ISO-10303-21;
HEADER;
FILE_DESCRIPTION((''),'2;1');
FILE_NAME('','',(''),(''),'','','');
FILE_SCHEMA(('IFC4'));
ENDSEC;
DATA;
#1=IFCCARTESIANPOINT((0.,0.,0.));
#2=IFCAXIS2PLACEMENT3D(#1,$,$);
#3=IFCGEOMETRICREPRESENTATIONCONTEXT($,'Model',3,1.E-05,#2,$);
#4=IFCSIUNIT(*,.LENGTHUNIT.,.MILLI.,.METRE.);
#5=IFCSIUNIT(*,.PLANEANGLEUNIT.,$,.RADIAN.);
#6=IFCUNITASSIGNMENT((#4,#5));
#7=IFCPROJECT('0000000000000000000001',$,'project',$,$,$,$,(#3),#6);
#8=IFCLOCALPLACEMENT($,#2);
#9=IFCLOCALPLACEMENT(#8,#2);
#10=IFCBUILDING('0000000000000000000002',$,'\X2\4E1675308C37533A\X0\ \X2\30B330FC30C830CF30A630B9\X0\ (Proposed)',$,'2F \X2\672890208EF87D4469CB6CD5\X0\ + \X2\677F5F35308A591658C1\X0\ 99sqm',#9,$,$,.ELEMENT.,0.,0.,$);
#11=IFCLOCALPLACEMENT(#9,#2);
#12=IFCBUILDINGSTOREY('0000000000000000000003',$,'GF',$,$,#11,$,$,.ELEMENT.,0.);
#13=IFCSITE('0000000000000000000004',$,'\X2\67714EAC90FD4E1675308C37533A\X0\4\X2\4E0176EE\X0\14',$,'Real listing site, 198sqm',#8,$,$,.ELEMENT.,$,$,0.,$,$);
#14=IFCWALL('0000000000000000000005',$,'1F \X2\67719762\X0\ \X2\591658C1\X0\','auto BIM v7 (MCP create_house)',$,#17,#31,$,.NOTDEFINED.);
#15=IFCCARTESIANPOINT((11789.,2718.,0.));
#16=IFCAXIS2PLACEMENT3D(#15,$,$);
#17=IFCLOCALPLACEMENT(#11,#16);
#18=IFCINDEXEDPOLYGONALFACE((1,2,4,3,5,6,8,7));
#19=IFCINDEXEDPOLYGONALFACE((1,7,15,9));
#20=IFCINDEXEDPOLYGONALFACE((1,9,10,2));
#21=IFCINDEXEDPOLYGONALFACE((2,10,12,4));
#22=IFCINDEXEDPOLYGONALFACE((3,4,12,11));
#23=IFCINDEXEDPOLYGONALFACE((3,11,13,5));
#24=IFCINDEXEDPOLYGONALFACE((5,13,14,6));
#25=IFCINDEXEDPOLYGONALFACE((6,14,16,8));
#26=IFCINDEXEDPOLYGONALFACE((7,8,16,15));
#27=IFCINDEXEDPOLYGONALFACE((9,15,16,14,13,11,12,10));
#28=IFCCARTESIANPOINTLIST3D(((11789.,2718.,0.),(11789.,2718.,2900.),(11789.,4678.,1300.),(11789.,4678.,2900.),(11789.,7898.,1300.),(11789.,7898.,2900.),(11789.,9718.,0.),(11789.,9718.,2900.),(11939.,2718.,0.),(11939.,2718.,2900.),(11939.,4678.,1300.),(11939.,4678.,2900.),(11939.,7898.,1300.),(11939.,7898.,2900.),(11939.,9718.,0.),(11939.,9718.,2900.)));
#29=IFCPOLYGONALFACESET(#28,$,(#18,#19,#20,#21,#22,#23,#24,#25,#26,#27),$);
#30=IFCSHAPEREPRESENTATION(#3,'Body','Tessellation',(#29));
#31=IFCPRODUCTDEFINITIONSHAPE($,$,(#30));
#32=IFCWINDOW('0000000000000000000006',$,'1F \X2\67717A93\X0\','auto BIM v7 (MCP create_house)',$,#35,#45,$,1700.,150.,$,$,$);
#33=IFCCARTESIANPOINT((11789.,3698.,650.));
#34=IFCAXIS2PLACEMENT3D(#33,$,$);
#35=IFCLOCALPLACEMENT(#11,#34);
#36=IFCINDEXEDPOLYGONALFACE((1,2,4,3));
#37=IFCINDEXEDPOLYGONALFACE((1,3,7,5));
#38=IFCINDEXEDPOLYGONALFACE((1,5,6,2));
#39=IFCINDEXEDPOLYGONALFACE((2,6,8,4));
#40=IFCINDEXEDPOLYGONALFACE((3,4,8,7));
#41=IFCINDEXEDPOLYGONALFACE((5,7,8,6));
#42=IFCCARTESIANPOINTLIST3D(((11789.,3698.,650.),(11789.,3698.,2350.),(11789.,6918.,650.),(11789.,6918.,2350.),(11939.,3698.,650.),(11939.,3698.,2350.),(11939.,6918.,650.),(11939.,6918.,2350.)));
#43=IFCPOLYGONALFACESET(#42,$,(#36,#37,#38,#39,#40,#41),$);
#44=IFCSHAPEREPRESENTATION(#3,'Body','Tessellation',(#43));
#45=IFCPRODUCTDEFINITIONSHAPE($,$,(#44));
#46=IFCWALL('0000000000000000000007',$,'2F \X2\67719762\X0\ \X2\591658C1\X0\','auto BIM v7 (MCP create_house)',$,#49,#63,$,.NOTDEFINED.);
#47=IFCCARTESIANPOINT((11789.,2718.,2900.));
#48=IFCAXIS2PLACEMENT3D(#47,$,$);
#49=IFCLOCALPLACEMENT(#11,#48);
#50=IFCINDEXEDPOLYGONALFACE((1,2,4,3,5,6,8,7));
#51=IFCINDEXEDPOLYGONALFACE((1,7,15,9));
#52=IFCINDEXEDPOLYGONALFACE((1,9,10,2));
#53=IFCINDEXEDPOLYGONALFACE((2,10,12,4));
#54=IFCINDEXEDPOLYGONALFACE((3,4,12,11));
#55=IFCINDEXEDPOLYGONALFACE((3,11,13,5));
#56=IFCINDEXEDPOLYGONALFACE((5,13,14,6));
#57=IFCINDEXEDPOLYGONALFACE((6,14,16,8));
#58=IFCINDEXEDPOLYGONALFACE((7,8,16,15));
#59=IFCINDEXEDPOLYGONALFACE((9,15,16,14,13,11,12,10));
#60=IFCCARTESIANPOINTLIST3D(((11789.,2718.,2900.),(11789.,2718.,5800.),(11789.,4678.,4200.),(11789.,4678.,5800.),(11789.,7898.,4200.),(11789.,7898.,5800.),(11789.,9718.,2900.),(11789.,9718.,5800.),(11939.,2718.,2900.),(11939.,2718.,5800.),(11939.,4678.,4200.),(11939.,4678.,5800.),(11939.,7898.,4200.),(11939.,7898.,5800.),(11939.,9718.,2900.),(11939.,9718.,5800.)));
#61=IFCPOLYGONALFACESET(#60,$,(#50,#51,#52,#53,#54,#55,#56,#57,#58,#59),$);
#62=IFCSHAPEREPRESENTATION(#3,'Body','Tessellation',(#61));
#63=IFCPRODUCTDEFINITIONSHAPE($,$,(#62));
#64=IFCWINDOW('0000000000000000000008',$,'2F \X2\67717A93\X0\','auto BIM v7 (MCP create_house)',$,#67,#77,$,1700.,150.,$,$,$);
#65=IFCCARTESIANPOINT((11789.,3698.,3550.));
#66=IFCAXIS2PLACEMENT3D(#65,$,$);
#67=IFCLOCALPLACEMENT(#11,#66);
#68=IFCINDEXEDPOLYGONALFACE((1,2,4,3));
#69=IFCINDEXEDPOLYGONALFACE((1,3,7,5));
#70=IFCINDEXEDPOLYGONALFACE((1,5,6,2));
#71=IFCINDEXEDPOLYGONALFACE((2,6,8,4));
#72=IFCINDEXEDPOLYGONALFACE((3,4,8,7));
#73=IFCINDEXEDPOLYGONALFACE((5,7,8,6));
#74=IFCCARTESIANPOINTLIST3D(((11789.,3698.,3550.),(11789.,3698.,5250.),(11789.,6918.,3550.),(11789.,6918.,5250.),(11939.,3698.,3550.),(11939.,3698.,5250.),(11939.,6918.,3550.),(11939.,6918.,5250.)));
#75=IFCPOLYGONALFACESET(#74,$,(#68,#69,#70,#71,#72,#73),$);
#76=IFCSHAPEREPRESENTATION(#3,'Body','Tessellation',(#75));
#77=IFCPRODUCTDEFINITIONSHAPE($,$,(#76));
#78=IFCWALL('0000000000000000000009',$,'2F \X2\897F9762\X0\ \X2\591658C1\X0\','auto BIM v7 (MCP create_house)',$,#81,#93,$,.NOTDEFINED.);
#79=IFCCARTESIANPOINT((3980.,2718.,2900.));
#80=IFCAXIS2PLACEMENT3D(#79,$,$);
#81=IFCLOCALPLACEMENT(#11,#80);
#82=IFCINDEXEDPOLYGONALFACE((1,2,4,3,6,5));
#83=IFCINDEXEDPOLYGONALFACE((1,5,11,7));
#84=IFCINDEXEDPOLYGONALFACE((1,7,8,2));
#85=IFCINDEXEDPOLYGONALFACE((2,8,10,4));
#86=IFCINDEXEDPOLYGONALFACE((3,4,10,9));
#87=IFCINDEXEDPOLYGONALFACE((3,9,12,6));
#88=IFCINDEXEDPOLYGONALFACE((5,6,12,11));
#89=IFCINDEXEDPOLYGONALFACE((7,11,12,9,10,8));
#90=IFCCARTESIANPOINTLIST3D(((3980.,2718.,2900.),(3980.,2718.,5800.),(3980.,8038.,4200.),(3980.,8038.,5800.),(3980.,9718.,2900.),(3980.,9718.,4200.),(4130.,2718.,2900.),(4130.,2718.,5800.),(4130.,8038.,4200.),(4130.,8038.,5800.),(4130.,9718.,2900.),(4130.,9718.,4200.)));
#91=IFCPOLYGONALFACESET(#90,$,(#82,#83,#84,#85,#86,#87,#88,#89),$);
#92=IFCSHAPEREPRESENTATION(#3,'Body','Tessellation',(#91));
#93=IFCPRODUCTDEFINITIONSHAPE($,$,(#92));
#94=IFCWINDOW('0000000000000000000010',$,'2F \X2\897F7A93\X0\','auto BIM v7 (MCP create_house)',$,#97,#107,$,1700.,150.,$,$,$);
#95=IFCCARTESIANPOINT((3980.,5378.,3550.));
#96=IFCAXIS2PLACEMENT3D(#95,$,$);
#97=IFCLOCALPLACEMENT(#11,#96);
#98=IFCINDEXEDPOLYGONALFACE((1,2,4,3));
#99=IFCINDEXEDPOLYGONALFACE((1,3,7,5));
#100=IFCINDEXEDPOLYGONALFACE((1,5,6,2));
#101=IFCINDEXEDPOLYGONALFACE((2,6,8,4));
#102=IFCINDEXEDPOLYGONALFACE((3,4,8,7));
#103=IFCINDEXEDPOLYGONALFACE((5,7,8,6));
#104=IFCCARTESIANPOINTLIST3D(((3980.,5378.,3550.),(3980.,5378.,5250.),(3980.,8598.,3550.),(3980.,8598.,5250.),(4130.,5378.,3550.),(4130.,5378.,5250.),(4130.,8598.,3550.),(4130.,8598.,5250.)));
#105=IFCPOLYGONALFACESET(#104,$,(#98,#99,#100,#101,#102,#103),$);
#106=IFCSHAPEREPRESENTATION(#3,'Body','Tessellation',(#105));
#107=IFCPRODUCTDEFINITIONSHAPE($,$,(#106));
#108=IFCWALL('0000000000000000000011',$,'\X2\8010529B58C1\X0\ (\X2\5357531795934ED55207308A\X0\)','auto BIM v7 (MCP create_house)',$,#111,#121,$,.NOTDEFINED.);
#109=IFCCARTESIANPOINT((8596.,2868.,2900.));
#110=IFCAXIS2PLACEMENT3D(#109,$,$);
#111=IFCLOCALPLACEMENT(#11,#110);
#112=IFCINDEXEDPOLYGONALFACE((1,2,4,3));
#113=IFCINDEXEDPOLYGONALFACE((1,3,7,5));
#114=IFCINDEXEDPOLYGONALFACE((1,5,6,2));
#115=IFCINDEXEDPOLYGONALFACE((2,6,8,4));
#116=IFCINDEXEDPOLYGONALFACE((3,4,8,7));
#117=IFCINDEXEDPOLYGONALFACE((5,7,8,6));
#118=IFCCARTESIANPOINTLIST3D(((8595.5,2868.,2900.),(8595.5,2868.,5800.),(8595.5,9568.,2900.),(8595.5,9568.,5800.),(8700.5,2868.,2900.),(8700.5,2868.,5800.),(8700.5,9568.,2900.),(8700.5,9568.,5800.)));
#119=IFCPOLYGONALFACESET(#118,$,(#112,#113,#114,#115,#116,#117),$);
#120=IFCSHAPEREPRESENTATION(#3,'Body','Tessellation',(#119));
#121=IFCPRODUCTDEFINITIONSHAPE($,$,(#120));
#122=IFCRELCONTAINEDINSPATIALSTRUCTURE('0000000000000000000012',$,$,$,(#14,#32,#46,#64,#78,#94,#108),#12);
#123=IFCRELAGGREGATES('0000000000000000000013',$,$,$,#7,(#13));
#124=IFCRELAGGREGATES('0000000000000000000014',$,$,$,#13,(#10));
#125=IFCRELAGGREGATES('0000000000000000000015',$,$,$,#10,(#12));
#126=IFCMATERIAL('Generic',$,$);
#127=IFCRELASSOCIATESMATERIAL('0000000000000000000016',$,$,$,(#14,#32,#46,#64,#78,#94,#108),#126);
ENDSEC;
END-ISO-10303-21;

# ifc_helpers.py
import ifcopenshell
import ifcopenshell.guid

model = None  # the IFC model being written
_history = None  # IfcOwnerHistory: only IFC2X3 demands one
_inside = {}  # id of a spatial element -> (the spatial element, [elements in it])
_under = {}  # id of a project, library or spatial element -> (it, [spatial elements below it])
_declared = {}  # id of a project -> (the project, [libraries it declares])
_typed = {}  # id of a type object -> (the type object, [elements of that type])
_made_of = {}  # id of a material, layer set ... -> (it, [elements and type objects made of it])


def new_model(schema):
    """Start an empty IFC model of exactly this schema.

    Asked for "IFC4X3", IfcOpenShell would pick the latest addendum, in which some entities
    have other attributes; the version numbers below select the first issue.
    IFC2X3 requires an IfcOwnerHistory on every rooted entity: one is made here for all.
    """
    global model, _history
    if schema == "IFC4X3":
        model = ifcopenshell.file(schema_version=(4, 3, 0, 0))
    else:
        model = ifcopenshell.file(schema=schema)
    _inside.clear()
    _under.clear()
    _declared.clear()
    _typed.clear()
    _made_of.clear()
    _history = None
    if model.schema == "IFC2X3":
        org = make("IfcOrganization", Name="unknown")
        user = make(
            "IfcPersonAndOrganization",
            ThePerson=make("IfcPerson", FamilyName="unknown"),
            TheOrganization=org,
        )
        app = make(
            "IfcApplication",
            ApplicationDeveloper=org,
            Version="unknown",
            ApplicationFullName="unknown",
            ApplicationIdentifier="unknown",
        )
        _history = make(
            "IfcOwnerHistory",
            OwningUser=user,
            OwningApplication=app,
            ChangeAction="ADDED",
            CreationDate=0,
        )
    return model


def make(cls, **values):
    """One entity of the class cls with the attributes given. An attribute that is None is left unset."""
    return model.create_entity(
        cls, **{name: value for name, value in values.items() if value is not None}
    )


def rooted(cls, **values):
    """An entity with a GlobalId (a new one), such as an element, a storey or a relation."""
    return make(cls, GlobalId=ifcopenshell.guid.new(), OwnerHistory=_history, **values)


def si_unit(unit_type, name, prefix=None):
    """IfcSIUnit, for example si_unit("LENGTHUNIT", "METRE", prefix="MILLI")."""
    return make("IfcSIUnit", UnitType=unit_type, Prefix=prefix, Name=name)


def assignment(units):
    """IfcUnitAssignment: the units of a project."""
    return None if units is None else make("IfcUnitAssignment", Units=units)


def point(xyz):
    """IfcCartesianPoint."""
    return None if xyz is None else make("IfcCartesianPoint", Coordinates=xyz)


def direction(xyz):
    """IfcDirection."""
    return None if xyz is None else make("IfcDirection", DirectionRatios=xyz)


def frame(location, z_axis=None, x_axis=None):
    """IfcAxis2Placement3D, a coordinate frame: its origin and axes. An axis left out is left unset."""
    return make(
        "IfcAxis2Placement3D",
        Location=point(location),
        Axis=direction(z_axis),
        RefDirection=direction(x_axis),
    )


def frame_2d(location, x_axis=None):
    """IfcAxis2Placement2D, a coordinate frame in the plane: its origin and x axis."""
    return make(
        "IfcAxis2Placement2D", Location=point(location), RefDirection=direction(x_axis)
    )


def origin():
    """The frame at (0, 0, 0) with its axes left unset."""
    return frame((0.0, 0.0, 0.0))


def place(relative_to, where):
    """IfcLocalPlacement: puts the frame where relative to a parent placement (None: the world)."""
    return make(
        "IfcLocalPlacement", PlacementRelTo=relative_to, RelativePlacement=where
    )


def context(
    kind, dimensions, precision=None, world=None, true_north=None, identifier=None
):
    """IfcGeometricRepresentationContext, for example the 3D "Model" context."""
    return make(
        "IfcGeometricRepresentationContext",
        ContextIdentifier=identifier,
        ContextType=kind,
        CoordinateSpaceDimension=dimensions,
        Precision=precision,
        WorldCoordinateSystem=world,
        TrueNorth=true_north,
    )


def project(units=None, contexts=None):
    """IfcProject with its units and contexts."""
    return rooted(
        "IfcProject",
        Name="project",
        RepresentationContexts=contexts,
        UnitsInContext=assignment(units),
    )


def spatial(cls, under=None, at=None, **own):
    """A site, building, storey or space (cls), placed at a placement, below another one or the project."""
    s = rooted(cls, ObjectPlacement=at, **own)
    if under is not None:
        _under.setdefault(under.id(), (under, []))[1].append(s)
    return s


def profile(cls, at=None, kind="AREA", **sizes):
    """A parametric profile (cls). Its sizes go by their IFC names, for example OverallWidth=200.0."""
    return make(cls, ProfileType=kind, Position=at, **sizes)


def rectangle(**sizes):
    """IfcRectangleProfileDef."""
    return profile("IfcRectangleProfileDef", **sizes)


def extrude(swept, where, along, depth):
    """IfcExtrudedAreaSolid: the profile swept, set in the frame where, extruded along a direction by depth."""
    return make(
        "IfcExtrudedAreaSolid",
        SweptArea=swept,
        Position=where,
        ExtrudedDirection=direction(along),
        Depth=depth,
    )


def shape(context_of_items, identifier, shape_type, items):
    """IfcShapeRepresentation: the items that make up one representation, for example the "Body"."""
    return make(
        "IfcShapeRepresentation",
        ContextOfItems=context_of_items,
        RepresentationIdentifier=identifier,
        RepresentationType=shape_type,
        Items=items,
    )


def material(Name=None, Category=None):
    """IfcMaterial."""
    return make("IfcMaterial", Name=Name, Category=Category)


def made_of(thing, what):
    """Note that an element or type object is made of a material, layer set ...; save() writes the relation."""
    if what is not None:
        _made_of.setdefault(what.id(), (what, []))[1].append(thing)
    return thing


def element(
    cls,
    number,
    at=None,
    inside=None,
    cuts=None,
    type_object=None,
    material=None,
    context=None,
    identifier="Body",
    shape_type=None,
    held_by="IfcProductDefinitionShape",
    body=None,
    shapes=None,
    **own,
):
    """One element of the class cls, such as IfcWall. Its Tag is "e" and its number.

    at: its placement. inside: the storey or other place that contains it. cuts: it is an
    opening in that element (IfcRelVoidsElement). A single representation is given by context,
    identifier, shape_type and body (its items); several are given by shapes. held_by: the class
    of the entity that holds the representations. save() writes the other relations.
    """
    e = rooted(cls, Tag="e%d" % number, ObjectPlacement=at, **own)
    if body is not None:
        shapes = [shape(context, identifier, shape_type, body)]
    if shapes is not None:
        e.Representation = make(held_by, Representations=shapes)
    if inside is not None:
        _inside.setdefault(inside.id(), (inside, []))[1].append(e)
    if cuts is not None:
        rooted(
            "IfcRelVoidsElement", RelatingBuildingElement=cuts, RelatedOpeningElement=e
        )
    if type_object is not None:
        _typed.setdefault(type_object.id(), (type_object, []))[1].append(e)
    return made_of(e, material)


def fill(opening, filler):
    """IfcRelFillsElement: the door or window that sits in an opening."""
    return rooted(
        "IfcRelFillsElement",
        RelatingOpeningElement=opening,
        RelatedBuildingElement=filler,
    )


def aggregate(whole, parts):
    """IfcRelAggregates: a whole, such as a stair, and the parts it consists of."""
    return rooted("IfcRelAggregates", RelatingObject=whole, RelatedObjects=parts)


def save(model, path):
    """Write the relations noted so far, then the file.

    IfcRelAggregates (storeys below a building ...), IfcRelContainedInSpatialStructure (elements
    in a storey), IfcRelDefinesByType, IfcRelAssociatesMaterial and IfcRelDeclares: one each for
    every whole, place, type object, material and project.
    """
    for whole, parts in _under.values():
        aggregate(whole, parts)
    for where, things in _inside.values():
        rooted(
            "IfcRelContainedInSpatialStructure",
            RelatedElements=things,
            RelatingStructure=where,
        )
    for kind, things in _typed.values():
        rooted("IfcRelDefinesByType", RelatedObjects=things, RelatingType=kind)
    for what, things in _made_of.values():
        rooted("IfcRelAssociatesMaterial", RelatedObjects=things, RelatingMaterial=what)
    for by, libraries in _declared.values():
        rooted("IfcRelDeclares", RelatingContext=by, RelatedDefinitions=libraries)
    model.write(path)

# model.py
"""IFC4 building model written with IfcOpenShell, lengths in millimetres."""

from ifc_helpers import new_model, si_unit, frame, frame_2d, origin, place, context, project, spatial, rectangle, extrude, material, element, fill, save


model = new_model("IFC4")

# Units and contexts
model_context = context("Model", 3, precision=1e-05, world=origin())
ifc_project = project(units=[si_unit("LENGTHUNIT", "METRE", prefix="MILLI"), si_unit("PLANEANGLEUNIT", "RADIAN")], contexts=[model_context])

# Site, building, storey
site_placement = place(None, origin())
site = spatial("IfcSite", under=ifc_project, at=site_placement, Name="東京都世田谷区4丁目14", ObjectType="Real listing site, 198sqm", CompositionType="ELEMENT", RefElevation=0.0)
building_placement = place(site_placement, origin())
building = spatial("IfcBuilding", under=site, at=building_placement, Name="世田谷区 コートハウス (Proposed)", ObjectType="2F 木造軸組構法 + 板張り外壁 99sqm", CompositionType="ELEMENT", ElevationOfRefHeight=0.0, ElevationOfTerrain=0.0)
storey_placement = place(building_placement, origin())
storey = spatial("IfcBuildingStorey", under=building, at=storey_placement, Name="GF", CompositionType="ELEMENT", Elevation=0.0)

# Shared definitions
ifc_material = material(Name="Generic")

# Wall, opening, window
wall_1_placement = place(storey_placement, frame((11789.0, 2718.0, 0.0)))
wall_1 = element("IfcWall", 1, at=wall_1_placement, inside=storey, material=ifc_material, Name="1F 東面 外壁", Description="auto BIM v7 (MCP create_house)", PredefinedType="NOTDEFINED", context=model_context, shape_type="SweptSolid", body=[
    extrude(rectangle(XDim=150.0, YDim=7000.0, at=frame_2d((75.0, 3500.0))), frame((11789.0, 2718.0, 0.0)), (0.0, 0.0, 1.0), 2900.0),
])
opening_1_placement = place(storey_placement, frame((11789.0, 3698.0, 650.0)))
opening_1 = element("IfcOpeningElement", 2, at=opening_1_placement, cuts=wall_1, PredefinedType="NOTDEFINED", context=model_context, shape_type="SweptSolid", body=[
    extrude(rectangle(XDim=150.0, YDim=3220.0, at=frame_2d((75.0, 1610.0))), frame((11789.0, 3698.0, 650.0)), (0.0, 0.0, 1.0), 1700.0),
])
window_1_placement = place(storey_placement, frame((11789.0, 3698.0, 650.0)))
window_1 = element("IfcWindow", 3, at=window_1_placement, inside=storey, material=ifc_material, Name="1F 東窓", Description="auto BIM v7 (MCP create_house)", OverallHeight=1700.0, OverallWidth=150.0, context=model_context, shape_type="SweptSolid", body=[
    extrude(rectangle(XDim=150.0, YDim=3220.0, at=frame_2d((75.0, 1610.0))), frame((11789.0, 3698.0, 650.0)), (0.0, 0.0, 1.0), 1700.0),
])
fill(opening_1, window_1)

# Walls, openings, windows
wall_2_placement = place(storey_placement, frame((11789.0, 2718.0, 2900.0)))
wall_2 = element("IfcWall", 4, at=wall_2_placement, inside=storey, material=ifc_material, Name="2F 東面 外壁", Description="auto BIM v7 (MCP create_house)", PredefinedType="NOTDEFINED", context=model_context, shape_type="SweptSolid", body=[
    extrude(rectangle(XDim=150.0, YDim=7000.0, at=frame_2d((75.0, 3500.0))), frame((11789.0, 2718.0, 2900.0)), (0.0, 0.0, 1.0), 2900.0),
])
opening_2_placement = place(storey_placement, frame((11789.0, 3698.0, 3550.0)))
opening_2 = element("IfcOpeningElement", 5, at=opening_2_placement, cuts=wall_2, PredefinedType="NOTDEFINED", context=model_context, shape_type="SweptSolid", body=[
    extrude(rectangle(XDim=150.0, YDim=3220.0, at=frame_2d((75.0, 1610.0))), frame((11789.0, 3698.0, 3550.0)), (0.0, 0.0, 1.0), 1700.0),
])
window_2_placement = place(storey_placement, frame((11789.0, 3698.0, 3550.0)))
window_2 = element("IfcWindow", 6, at=window_2_placement, inside=storey, material=ifc_material, Name="2F 東窓", Description="auto BIM v7 (MCP create_house)", OverallHeight=1700.0, OverallWidth=150.0, context=model_context, shape_type="SweptSolid", body=[
    extrude(rectangle(XDim=150.0, YDim=3220.0, at=frame_2d((75.0, 1610.0))), frame((11789.0, 3698.0, 3550.0)), (0.0, 0.0, 1.0), 1700.0),
])
fill(opening_2, window_2)
wall_3_placement = place(storey_placement, frame((3980.0, 2718.0, 2900.0)))
wall_3 = element("IfcWall", 7, at=wall_3_placement, inside=storey, material=ifc_material, Name="2F 西面 外壁", Description="auto BIM v7 (MCP create_house)", PredefinedType="NOTDEFINED", context=model_context, shape_type="SweptSolid", body=[
    extrude(rectangle(XDim=150.0, YDim=7000.0, at=frame_2d((75.0, 3500.0))), frame((3980.0, 2718.0, 2900.0)), (0.0, 0.0, 1.0), 2900.0),
])
opening_3_placement = place(storey_placement, frame((3980.0, 5378.0, 3550.0)))
opening_3 = element("IfcOpeningElement", 8, at=opening_3_placement, cuts=wall_3, PredefinedType="NOTDEFINED", context=model_context, shape_type="SweptSolid", body=[
    extrude(rectangle(XDim=150.0, YDim=3220.0, at=frame_2d((75.0, 1610.0))), frame((3980.0, 5378.0, 3550.0)), (0.0, 0.0, 1.0), 1700.0),
])
window_3_placement = place(storey_placement, frame((3980.0, 5378.0, 3550.0)))
window_3 = element("IfcWindow", 9, at=window_3_placement, inside=storey, material=ifc_material, Name="2F 西窓", Description="auto BIM v7 (MCP create_house)", OverallHeight=1700.0, OverallWidth=150.0, context=model_context, shape_type="SweptSolid", body=[
    extrude(rectangle(XDim=150.0, YDim=3220.0, at=frame_2d((75.0, 1610.0))), frame((3980.0, 5378.0, 3550.0)), (0.0, 0.0, 1.0), 1700.0),
])
fill(opening_3, window_3)

# Wall
wall_4_placement = place(storey_placement, frame((8596.0, 2868.0, 2900.0)))
element("IfcWall", 10, at=wall_4_placement, inside=storey, material=ifc_material, Name="耐力壁 (南北間仕切り)", Description="auto BIM v7 (MCP create_house)", PredefinedType="NOTDEFINED", context=model_context, shape_type="SweptSolid", body=[
    extrude(rectangle(XDim=105.0, YDim=6700.0, at=frame_2d((52.0, 3350.0))), frame((8596.0, 2868.0, 2900.0)), (0.0, 0.0, 1.0), 2900.0),
])

save(model, "model.ifc")
